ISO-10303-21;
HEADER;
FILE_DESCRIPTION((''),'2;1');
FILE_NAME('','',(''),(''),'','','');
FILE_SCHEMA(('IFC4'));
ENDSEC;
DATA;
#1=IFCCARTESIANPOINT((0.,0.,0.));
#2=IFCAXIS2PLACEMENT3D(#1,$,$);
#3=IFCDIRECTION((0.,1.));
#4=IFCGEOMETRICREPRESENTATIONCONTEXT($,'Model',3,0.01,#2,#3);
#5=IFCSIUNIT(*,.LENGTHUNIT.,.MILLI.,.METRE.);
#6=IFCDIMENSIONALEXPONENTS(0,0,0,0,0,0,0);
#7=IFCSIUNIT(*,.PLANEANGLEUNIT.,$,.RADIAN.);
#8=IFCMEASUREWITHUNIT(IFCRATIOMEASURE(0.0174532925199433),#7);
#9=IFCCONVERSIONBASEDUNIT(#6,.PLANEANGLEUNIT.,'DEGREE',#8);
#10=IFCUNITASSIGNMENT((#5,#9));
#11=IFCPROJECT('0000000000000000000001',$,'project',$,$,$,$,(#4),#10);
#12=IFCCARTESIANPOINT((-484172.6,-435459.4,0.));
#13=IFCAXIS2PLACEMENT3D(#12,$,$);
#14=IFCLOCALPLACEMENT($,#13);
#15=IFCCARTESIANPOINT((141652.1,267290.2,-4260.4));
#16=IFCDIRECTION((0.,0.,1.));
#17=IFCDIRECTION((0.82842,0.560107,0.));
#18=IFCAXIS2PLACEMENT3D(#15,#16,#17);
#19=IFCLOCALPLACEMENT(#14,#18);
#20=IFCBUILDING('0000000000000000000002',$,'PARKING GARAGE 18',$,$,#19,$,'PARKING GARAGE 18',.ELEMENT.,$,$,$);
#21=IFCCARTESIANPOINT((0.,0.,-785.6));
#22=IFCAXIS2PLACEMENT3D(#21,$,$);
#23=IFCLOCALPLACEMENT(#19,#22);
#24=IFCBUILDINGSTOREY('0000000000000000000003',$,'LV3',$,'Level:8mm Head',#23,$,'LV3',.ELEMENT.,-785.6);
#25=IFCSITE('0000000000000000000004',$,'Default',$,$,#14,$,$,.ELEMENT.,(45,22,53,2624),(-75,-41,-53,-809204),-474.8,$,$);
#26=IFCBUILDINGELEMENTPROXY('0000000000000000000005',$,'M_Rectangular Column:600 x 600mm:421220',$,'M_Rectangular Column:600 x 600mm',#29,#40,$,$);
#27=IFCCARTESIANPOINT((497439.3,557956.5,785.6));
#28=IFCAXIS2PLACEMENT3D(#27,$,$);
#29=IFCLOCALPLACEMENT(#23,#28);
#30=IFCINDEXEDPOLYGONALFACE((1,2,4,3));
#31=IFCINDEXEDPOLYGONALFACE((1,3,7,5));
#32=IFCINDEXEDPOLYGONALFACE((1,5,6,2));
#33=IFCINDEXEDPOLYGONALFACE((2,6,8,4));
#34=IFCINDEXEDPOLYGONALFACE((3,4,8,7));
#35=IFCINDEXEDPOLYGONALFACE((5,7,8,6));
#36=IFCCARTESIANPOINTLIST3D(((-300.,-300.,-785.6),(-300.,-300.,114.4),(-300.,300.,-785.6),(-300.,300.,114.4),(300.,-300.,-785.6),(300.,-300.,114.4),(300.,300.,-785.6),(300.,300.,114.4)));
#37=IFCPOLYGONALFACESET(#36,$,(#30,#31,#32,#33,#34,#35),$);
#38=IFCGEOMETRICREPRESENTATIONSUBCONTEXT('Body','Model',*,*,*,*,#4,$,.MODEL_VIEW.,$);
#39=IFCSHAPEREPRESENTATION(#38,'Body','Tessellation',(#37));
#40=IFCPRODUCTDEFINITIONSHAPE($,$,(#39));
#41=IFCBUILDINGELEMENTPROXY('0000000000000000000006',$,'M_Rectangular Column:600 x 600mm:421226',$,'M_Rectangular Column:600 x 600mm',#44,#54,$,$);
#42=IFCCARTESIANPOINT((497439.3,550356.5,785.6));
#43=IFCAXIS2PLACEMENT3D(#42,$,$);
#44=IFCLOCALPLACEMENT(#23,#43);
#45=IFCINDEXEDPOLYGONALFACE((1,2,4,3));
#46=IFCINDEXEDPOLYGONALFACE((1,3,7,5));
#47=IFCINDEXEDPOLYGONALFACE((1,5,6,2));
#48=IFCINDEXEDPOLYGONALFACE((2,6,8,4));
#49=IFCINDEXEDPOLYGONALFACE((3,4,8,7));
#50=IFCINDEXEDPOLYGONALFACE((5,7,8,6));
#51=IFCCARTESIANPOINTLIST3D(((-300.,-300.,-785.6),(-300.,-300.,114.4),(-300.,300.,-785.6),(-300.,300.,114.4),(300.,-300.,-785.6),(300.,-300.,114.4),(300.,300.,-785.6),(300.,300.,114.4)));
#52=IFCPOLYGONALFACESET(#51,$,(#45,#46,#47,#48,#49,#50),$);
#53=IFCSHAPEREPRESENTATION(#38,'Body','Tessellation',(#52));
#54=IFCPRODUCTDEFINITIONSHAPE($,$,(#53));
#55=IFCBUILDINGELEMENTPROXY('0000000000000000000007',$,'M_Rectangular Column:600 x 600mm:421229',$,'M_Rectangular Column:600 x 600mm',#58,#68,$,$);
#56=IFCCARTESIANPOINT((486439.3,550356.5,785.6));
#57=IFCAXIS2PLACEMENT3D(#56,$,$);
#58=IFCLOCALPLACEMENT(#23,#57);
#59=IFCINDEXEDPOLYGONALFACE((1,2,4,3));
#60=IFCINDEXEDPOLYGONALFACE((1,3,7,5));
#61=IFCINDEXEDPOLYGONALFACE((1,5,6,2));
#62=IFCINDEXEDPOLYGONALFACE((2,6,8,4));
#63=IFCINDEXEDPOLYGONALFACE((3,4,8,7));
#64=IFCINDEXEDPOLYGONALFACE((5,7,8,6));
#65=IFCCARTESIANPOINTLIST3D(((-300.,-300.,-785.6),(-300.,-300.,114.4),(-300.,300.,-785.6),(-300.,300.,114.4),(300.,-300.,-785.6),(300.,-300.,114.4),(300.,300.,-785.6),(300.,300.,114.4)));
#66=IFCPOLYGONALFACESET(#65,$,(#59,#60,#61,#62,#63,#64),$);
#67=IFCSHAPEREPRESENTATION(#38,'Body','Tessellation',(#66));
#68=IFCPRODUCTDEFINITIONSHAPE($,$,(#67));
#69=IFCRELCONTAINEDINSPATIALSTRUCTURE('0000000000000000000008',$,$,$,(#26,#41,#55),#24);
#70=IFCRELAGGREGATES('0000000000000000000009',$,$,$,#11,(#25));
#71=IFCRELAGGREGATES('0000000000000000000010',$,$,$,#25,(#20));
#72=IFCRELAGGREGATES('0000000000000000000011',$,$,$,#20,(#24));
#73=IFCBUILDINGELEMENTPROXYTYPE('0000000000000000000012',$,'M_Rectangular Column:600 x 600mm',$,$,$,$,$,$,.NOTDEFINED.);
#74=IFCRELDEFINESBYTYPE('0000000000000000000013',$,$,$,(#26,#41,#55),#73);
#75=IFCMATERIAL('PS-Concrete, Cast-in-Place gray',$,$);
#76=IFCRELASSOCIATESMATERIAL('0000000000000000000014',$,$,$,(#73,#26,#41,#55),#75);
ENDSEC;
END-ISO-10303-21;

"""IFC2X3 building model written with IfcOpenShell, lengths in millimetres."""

from ifc_helpers import new_model, entity, si_unit, converted_unit, direction, frame, origin, origin_2d_with_axis, place, context, subcontext, project, spatial, rectangle, extrude, source, transform, mapped, material, type_object, type_shapes, element, save


model = new_model("IFC2X3")

# Units and contexts
model_context = context("Model", 3, precision=0.01, world=origin(), true_north=direction((0.0, 1.0)))
body_context = subcontext(model_context, "Body", "Model", "MODEL_VIEW")
ifc_project = project(units=[si_unit("LENGTHUNIT", "METRE", prefix="MILLI"), converted_unit("PLANEANGLEUNIT", "DEGREE", entity("IfcRatioMeasure", 0.0174532925199433), si_unit("PLANEANGLEUNIT", "RADIAN"), dimensions=[0, 0, 0, 0, 0, 0, 0])], contexts=[model_context])

# Site, building, storey
site_placement = place(None, frame((-484172.6, -435459.4, 0.0)))
site = spatial("IfcSite", under=ifc_project, at=site_placement, Name="Default", CompositionType="ELEMENT", RefLatitude=(45, 22, 53, 2624), RefLongitude=(-75, -41, -53, -809204), RefElevation=-474.8)
building_placement = place(site_placement, frame((141652.1, 267290.2, -4260.4), z_axis=(0.0, 0.0, 1.0), x_axis=(0.82842, 0.560107, 0.0)))
building = spatial("IfcBuilding", under=site, at=building_placement, Name="PARKING GARAGE 18", LongName="PARKING GARAGE 18", CompositionType="ELEMENT")
storey_placement = place(building_placement, frame((0.0, 0.0, -785.6)))
storey = spatial("IfcBuildingStorey", under=building, at=storey_placement, Name="LV3", ObjectType="Level:8mm Head", LongName="LV3", CompositionType="ELEMENT", Elevation=-785.6)

# Shared definitions
ifc_material_1 = material(Name="PS-Concrete, Cast-in-Place gray")

# Building element proxies
building_element_proxy_type_1 = type_object("IfcBuildingElementProxyType", Name="M_Rectangular Column:600 x 600mm", PredefinedType="NOTDEFINED", material=ifc_material_1)
shared_shape_1 = source(origin(), body_context, "Body", "SweptSolid", [
    extrude(rectangle(XDim=600.0, YDim=600.0, at=origin_2d_with_axis()), frame((0.0, 0.0, -785.6), z_axis=(0.0, 0.0, 1.0), x_axis=(0.0, 1.0, 0.0)), (0.0, 0.0, 1.0), 900.0),
])
type_shapes(building_element_proxy_type_1, [shared_shape_1])
for number, where, name in (
    (1, (497439.3, 557956.5, 785.6), "M_Rectangular Column:600 x 600mm:421220"),
    (2, (497439.3, 550356.5, 785.6), "M_Rectangular Column:600 x 600mm:421226"),
    (3, (486439.3, 550356.5, 785.6), "M_Rectangular Column:600 x 600mm:421229"),
):
    element("IfcBuildingElementProxy", number, at=place(storey_placement, frame(where)), inside=storey, type_object=building_element_proxy_type_1, material=ifc_material_1, Name=name, ObjectType="M_Rectangular Column:600 x 600mm", context=body_context, shape_type="MappedRepresentation", body=[
        mapped(shared_shape_1, transform((0.0, 0.0, 0.0), scale=1.0)),
    ])

save(model, "model.ifc")
